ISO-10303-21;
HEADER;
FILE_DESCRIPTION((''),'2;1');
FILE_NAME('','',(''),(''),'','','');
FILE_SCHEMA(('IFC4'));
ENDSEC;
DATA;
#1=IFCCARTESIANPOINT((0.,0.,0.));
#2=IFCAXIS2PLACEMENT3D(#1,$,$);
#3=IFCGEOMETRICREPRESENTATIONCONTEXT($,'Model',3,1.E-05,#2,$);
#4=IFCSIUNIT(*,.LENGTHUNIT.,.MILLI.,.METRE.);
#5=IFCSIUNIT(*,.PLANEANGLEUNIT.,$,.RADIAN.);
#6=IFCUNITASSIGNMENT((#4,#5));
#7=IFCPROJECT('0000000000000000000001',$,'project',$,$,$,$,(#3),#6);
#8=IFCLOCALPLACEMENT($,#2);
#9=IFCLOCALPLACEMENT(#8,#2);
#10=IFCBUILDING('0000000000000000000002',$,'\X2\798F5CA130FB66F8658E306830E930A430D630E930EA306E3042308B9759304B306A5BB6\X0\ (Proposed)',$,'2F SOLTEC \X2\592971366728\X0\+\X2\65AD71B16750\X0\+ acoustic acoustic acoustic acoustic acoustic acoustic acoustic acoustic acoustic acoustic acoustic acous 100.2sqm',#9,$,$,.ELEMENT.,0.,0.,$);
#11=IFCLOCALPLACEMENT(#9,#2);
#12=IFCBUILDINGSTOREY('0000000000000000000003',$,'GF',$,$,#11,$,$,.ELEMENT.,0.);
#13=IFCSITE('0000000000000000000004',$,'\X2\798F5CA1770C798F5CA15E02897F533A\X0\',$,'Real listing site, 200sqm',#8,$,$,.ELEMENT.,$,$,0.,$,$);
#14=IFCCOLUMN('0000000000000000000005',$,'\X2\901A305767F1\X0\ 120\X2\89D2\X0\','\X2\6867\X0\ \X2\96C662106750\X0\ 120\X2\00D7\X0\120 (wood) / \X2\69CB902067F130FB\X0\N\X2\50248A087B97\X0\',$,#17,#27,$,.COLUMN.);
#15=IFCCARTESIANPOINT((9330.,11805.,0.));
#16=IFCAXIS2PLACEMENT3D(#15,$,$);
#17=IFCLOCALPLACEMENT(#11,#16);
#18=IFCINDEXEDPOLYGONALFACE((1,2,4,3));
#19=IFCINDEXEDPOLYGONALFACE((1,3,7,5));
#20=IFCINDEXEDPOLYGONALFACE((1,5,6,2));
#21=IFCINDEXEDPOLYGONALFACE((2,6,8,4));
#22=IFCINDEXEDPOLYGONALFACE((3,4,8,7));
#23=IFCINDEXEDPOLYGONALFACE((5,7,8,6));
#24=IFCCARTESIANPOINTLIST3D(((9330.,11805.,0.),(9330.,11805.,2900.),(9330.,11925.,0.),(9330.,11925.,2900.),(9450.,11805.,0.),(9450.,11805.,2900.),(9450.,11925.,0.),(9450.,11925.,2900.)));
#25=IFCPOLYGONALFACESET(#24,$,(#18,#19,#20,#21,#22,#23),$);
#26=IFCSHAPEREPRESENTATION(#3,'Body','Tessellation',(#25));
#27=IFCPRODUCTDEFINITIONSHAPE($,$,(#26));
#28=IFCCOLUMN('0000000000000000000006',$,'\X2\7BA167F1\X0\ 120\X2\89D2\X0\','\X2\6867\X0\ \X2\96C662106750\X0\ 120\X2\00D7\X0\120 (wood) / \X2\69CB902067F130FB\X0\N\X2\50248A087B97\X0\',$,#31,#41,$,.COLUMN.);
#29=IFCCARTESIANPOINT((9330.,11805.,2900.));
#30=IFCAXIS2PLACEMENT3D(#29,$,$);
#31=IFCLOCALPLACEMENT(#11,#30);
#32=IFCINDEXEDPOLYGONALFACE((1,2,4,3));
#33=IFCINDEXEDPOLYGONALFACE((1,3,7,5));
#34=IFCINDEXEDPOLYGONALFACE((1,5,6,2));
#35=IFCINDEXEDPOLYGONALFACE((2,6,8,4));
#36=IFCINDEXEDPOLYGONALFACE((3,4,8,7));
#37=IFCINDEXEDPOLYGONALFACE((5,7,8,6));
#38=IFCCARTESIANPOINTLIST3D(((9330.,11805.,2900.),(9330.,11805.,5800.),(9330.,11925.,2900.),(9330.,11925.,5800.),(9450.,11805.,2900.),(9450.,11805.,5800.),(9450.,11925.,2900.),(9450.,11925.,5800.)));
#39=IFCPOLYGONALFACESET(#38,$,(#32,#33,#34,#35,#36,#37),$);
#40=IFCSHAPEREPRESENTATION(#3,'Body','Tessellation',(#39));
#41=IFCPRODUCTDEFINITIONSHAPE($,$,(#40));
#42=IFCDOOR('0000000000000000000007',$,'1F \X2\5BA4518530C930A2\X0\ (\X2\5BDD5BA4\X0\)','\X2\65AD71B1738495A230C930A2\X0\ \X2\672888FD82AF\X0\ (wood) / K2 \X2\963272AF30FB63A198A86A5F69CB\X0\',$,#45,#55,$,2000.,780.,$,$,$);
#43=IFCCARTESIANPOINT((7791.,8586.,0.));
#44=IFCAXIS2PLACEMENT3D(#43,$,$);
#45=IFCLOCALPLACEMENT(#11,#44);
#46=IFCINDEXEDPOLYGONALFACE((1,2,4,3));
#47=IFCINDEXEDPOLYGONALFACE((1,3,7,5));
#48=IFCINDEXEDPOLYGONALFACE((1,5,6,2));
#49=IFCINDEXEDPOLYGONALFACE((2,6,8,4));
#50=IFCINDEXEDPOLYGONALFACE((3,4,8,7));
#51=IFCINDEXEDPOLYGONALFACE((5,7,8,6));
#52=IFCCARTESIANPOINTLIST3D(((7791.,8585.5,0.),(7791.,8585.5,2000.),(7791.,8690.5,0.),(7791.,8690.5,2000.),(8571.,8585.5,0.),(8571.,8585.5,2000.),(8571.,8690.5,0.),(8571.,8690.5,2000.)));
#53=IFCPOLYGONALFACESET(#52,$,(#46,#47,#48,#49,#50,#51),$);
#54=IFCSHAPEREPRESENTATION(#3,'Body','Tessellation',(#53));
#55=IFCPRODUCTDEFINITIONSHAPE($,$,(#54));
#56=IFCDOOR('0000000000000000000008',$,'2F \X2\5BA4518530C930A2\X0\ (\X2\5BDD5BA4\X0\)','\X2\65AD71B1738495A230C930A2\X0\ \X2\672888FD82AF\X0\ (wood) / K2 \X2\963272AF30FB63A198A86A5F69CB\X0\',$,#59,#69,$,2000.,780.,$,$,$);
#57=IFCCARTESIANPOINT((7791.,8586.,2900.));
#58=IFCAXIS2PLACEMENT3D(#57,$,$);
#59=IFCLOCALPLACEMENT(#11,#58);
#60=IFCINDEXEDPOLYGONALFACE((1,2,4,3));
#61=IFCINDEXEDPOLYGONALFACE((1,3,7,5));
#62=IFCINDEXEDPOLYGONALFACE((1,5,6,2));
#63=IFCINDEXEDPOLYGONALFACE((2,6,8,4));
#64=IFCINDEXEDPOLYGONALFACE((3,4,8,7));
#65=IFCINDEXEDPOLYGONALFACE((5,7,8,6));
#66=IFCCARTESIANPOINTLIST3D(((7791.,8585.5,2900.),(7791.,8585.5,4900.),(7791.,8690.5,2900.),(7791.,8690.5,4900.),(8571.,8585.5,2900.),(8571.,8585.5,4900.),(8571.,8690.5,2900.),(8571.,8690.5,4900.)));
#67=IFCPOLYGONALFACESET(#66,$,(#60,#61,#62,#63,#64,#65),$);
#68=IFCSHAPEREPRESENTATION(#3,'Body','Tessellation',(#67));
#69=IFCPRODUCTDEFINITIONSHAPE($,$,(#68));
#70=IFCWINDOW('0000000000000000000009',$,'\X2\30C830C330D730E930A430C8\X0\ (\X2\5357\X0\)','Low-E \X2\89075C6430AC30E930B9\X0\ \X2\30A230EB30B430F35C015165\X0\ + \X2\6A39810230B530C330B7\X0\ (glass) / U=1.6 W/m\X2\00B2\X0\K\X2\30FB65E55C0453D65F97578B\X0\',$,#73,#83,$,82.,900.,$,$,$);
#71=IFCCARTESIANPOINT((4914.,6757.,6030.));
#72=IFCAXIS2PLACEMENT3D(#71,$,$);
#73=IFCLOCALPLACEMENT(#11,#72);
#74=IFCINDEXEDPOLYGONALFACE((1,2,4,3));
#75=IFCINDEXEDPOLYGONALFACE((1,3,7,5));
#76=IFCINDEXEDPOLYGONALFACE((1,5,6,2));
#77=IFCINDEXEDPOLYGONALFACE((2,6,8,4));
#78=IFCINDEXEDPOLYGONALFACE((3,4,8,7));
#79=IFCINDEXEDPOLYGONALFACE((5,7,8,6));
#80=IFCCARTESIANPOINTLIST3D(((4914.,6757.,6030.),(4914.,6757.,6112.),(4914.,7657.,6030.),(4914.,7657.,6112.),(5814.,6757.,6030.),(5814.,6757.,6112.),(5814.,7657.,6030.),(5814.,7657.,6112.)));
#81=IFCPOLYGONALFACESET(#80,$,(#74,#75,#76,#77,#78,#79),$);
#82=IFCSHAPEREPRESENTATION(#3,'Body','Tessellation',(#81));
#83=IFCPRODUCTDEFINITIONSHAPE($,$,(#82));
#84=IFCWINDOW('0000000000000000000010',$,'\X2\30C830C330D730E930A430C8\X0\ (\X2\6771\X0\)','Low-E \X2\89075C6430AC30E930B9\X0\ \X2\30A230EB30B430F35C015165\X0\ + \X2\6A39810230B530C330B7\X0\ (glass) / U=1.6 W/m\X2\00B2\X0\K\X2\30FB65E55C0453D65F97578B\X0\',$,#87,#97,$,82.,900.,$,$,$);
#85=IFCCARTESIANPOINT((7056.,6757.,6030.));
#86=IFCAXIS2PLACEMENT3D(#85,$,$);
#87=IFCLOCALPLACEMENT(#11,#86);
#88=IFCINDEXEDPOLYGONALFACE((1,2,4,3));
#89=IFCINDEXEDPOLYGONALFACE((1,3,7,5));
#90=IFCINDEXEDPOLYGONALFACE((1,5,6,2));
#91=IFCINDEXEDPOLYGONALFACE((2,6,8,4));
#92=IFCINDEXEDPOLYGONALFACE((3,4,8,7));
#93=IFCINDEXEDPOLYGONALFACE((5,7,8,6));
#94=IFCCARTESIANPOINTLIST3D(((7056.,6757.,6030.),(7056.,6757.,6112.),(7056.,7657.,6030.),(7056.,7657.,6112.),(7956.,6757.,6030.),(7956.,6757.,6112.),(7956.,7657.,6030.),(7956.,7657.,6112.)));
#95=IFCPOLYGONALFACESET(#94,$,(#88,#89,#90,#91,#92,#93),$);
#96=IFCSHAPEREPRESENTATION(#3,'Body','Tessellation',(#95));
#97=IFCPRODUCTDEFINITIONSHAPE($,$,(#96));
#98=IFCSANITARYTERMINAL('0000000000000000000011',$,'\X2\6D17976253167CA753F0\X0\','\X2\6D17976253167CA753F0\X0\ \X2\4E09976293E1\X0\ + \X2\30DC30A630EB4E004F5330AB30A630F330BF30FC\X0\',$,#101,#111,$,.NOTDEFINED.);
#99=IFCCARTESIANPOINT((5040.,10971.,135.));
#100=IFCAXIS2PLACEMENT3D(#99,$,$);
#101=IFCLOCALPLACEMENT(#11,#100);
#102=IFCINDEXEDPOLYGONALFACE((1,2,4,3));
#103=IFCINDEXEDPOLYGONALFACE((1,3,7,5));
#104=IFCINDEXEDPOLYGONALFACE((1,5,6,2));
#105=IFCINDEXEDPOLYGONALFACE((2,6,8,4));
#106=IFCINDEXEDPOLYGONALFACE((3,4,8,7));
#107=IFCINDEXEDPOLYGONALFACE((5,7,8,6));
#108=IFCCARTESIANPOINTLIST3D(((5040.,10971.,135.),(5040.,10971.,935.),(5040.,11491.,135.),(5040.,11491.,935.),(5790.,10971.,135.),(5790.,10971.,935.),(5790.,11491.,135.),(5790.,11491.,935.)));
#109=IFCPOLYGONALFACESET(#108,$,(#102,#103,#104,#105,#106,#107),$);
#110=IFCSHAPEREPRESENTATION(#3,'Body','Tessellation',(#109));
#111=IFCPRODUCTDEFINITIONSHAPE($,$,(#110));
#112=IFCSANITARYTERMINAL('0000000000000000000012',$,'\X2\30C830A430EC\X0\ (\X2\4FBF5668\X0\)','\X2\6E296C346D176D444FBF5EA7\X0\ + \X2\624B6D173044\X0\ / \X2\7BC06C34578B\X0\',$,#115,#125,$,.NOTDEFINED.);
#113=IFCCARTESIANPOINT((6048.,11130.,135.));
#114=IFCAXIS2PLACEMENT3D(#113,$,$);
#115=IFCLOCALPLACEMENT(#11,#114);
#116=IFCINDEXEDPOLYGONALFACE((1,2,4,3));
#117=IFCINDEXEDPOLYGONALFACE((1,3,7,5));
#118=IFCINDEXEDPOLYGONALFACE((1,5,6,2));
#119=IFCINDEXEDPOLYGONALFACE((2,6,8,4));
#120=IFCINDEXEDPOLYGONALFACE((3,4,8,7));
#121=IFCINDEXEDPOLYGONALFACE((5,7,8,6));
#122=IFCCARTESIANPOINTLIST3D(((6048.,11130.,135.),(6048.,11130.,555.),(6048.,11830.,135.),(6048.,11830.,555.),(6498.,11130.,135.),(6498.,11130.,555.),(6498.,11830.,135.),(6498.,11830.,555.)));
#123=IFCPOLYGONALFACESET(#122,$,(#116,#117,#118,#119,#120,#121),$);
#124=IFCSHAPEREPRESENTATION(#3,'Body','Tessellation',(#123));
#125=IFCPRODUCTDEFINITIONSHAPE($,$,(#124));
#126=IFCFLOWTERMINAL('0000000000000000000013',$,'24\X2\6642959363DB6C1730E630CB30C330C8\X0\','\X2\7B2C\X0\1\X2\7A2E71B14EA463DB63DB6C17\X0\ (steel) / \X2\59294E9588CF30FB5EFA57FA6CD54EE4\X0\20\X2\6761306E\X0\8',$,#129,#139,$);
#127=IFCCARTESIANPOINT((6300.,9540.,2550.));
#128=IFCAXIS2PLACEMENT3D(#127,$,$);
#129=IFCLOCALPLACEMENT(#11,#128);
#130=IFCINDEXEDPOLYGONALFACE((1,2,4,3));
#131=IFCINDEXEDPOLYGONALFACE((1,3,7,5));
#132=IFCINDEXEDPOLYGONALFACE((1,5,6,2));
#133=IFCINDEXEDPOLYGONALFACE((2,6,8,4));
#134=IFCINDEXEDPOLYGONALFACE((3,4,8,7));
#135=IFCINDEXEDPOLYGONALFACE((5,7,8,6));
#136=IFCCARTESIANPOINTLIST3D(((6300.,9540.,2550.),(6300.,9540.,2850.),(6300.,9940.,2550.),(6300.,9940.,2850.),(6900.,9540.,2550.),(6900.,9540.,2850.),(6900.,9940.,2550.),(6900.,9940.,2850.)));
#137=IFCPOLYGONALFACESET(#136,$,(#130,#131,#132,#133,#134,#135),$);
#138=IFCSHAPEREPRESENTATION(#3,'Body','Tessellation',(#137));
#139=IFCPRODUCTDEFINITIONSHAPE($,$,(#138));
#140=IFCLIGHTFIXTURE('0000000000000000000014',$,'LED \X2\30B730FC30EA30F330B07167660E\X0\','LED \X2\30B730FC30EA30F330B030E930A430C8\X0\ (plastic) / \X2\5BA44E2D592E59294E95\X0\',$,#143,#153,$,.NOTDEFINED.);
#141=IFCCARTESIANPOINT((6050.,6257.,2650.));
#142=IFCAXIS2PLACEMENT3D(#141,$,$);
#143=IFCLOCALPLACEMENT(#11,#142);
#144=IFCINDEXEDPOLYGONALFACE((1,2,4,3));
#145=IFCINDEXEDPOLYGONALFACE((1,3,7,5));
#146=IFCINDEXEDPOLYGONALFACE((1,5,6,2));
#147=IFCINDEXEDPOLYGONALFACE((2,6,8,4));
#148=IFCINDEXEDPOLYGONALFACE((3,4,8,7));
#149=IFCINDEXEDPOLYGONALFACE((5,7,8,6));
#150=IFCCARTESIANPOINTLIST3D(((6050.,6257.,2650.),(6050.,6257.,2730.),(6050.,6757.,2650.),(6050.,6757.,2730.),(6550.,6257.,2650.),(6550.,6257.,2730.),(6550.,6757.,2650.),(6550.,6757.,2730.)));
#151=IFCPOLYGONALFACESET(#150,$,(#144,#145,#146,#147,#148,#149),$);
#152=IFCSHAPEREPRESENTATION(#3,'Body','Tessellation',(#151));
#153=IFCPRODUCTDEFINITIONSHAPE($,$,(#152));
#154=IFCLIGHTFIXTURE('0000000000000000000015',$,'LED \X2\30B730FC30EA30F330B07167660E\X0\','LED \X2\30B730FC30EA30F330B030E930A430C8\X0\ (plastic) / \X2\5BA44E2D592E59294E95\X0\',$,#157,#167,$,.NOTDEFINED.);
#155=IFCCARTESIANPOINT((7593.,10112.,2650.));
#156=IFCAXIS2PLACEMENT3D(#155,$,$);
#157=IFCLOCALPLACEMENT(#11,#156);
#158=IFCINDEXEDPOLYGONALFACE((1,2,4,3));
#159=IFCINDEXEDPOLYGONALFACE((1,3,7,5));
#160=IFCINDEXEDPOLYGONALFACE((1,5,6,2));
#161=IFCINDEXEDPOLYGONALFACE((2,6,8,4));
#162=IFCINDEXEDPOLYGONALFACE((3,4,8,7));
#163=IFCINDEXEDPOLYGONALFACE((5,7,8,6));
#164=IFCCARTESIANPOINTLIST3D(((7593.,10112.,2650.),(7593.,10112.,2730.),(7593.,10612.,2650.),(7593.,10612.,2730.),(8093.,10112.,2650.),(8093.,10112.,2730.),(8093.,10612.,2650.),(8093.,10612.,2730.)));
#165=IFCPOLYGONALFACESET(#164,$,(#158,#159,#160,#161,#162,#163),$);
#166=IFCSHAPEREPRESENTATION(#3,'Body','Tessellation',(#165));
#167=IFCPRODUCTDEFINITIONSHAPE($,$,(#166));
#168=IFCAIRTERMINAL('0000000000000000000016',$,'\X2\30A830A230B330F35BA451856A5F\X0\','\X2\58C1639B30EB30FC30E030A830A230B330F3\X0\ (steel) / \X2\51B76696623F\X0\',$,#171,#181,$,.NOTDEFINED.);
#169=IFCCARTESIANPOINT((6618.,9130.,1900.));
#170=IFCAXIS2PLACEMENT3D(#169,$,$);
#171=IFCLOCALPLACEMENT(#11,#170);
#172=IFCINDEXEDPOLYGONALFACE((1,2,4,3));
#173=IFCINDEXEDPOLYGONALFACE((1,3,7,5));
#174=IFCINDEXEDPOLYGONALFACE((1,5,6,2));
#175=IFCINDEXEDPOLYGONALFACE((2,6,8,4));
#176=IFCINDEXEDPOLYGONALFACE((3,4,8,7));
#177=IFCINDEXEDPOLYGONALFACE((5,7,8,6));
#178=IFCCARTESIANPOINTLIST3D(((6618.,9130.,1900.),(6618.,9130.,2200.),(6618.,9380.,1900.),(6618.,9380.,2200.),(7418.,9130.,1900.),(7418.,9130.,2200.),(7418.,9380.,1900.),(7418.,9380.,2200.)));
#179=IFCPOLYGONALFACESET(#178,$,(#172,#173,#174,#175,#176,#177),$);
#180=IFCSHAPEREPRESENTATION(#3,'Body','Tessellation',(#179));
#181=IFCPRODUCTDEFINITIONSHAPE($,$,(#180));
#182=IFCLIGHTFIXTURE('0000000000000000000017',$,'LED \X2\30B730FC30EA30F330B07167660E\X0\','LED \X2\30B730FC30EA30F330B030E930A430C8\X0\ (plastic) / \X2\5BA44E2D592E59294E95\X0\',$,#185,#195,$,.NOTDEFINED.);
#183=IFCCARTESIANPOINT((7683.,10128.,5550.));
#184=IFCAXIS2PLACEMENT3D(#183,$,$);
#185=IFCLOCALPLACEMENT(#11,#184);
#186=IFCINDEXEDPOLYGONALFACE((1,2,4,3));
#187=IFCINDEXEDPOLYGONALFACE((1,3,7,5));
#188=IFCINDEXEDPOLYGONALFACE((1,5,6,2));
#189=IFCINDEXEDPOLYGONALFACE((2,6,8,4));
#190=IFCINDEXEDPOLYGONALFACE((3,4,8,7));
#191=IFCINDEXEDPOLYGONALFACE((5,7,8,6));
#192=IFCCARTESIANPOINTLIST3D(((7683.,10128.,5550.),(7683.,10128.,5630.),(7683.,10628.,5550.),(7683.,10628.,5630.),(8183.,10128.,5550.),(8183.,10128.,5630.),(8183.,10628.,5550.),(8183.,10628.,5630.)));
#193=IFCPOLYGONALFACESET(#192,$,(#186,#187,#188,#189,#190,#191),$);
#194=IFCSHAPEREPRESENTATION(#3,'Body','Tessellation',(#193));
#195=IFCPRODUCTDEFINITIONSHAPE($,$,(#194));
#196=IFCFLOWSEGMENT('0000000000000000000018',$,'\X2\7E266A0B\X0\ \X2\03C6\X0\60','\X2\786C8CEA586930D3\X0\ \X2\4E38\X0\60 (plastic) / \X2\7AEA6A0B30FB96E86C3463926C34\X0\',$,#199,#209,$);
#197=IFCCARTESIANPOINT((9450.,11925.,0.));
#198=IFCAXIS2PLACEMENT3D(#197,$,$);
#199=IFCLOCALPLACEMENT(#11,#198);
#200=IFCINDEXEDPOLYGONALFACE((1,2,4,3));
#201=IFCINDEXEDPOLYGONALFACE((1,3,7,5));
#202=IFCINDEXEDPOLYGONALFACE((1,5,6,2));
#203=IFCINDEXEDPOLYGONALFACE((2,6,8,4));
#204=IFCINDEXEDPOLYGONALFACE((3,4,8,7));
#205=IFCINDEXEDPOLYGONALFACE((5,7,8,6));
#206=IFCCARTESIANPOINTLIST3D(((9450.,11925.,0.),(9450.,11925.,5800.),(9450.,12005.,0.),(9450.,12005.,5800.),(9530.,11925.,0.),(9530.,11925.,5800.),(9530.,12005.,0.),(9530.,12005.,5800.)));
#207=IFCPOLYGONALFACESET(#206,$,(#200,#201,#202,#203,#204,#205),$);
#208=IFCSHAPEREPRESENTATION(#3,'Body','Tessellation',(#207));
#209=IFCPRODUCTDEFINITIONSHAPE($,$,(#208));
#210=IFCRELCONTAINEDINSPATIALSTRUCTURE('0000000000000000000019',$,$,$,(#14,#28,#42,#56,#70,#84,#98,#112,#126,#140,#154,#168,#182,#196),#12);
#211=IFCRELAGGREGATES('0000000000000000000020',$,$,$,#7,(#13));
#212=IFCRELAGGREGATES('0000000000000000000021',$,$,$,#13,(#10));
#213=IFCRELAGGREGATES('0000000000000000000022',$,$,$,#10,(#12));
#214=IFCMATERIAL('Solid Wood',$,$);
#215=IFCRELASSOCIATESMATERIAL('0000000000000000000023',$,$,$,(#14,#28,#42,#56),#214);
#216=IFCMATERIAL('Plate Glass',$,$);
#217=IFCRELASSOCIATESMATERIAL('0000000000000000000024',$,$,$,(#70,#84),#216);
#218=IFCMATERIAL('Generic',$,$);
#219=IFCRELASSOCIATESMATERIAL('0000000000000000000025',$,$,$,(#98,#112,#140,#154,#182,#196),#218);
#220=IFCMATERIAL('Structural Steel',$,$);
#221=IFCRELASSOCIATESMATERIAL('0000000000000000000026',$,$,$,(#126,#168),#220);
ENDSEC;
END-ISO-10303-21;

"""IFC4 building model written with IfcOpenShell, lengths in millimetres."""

from ifc_helpers import new_model, si_unit, frame, frame_2d, origin, place, context, project, spatial, rectangle, extrude, material, element, save


model = new_model("IFC4")

# Units and contexts
model_context = context("Model", 3, precision=1e-05, world=origin())
ifc_project = project(units=[si_unit("LENGTHUNIT", "METRE", prefix="MILLI"), si_unit("PLANEANGLEUNIT", "RADIAN")], contexts=[model_context])

# Site, building, storey
site_placement = place(None, origin())
site = spatial("IfcSite", under=ifc_project, at=site_placement, Name="福岡県福岡市西区", ObjectType="Real listing site, 200sqm", CompositionType="ELEMENT", RefElevation=0.0)
building_placement = place(site_placement, origin())
building = spatial("IfcBuilding", under=site, at=building_placement, Name="福岡・書斎とライブラリのある静かな家 (Proposed)", ObjectType="2F SOLTEC 天然木+断熱材+ acoustic acoustic acoustic acoustic acoustic acoustic acoustic acoustic acoustic acoustic acoustic acous 100.2sqm", CompositionType="ELEMENT", ElevationOfRefHeight=0.0, ElevationOfTerrain=0.0)
storey_placement = place(building_placement, origin())
storey = spatial("IfcBuildingStorey", under=building, at=storey_placement, Name="GF", CompositionType="ELEMENT", Elevation=0.0)

# Columns
ifc_material_1 = material(Name="Solid Wood")
column_1_placement = place(storey_placement, frame((9330.0, 11805.0, 0.0)))
element("IfcColumn", 1, at=column_1_placement, inside=storey, material=ifc_material_1, Name="通し柱 120角", Description="桧 集成材 120×120 (wood) / 構造柱・N値計算", PredefinedType="COLUMN", context=model_context, shape_type="SweptSolid", body=[
    extrude(rectangle(XDim=120.0, YDim=120.0, at=frame_2d((60.0, 60.0))), frame((9330.0, 11805.0, 0.0)), (0.0, 0.0, 1.0), 2900.0),
])
column_2_placement = place(storey_placement, frame((9330.0, 11805.0, 2900.0)))
element("IfcColumn", 2, at=column_2_placement, inside=storey, material=ifc_material_1, Name="管柱 120角", Description="桧 集成材 120×120 (wood) / 構造柱・N値計算", PredefinedType="COLUMN", context=model_context, shape_type="SweptSolid", body=[
    extrude(rectangle(XDim=120.0, YDim=120.0, at=frame_2d((60.0, 60.0))), frame((9330.0, 11805.0, 2900.0)), (0.0, 0.0, 1.0), 2900.0),
])

# Door
door_1_placement = place(storey_placement, frame((7791.0, 8586.0, 0.0)))
element("IfcDoor", 3, at=door_1_placement, inside=storey, material=ifc_material_1, Name="1F 室内ドア (寝室)", Description="断熱玄関ドア 木製芯 (wood) / K2 防犯・採風機構", OverallHeight=2000.0, OverallWidth=780.0, context=model_context, shape_type="SweptSolid", body=[
    extrude(rectangle(XDim=780.0, YDim=105.0, at=frame_2d((390.0, 52.0))), frame((7791.0, 8586.0, 0.0)), (0.0, 0.0, 1.0), 2000.0),
])

# Door
door_2_placement = place(storey_placement, frame((7791.0, 8586.0, 2900.0)))
element("IfcDoor", 4, at=door_2_placement, inside=storey, material=ifc_material_1, Name="2F 室内ドア (寝室)", Description="断熱玄関ドア 木製芯 (wood) / K2 防犯・採風機構", OverallHeight=2000.0, OverallWidth=780.0, context=model_context, shape_type="SweptSolid", body=[
    extrude(rectangle(XDim=780.0, YDim=105.0, at=frame_2d((390.0, 52.0))), frame((7791.0, 8586.0, 2900.0)), (0.0, 0.0, 1.0), 2000.0),
])

# Windows
ifc_material_2 = material(Name="Plate Glass")
window_1_placement = place(storey_placement, frame((4914.0, 6757.0, 6030.0)))
element("IfcWindow", 5, at=window_1_placement, inside=storey, material=ifc_material_2, Name="トップライト (南)", Description="Low-E 複層ガラス アルゴン封入 + 樹脂サッシ (glass) / U=1.6 W/m²K・日射取得型", OverallHeight=82.0, OverallWidth=900.0, context=model_context, shape_type="SweptSolid", body=[
    extrude(rectangle(XDim=900.0, YDim=900.0, at=frame_2d((450.0, 450.0))), frame((4914.0, 6757.0, 6030.0)), (0.0, 0.0, 1.0), 82.0),
])
window_2_placement = place(storey_placement, frame((7056.0, 6757.0, 6030.0)))
element("IfcWindow", 6, at=window_2_placement, inside=storey, material=ifc_material_2, Name="トップライト (東)", Description="Low-E 複層ガラス アルゴン封入 + 樹脂サッシ (glass) / U=1.6 W/m²K・日射取得型", OverallHeight=82.0, OverallWidth=900.0, context=model_context, shape_type="SweptSolid", body=[
    extrude(rectangle(XDim=900.0, YDim=900.0, at=frame_2d((450.0, 450.0))), frame((7056.0, 6757.0, 6030.0)), (0.0, 0.0, 1.0), 82.0),
])

# Sanitary terminals
ifc_material_3 = material(Name="Generic")
sanitary_terminal_1_placement = place(storey_placement, frame((5040.0, 10971.0, 135.0)))
element("IfcSanitaryTerminal", 7, at=sanitary_terminal_1_placement, inside=storey, material=ifc_material_3, Name="洗面化粧台", Description="洗面化粧台 三面鏡 + ボウル一体カウンター", PredefinedType="NOTDEFINED", context=model_context, shape_type="SweptSolid", body=[
    extrude(rectangle(XDim=750.0, YDim=520.0, at=frame_2d((375.0, 260.0))), frame((5040.0, 10971.0, 135.0)), (0.0, 0.0, 1.0), 800.0),
])
sanitary_terminal_2_placement = place(storey_placement, frame((6048.0, 11130.0, 135.0)))
element("IfcSanitaryTerminal", 8, at=sanitary_terminal_2_placement, inside=storey, material=ifc_material_3, Name="トイレ (便器)", Description="温水洗浄便座 + 手洗い / 節水型", PredefinedType="NOTDEFINED", context=model_context, shape_type="SweptSolid", body=[
    extrude(rectangle(XDim=450.0, YDim=700.0, at=frame_2d((225.0, 350.0))), frame((6048.0, 11130.0, 135.0)), (0.0, 0.0, 1.0), 420.0),
])

# Flow terminal
ifc_material_4 = material(Name="Structural Steel")
flow_terminal_placement = place(storey_placement, frame((6300.0, 9540.0, 2550.0)))
element("IfcFlowTerminal", 9, at=flow_terminal_placement, inside=storey, material=ifc_material_4, Name="24時間換気ユニット", Description="第1種熱交換換気 (steel) / 天井裏・建基法令20条の8", context=model_context, shape_type="SweptSolid", body=[
    extrude(rectangle(XDim=600.0, YDim=400.0, at=frame_2d((300.0, 200.0))), frame((6300.0, 9540.0, 2550.0)), (0.0, 0.0, 1.0), 300.0),
])

# Light fixtures
light_fixture_1_placement = place(storey_placement, frame((6050.0, 6257.0, 2650.0)))
element("IfcLightFixture", 10, at=light_fixture_1_placement, inside=storey, material=ifc_material_3, Name="LED シーリング照明", Description="LED シーリングライト (plastic) / 室中央天井", PredefinedType="NOTDEFINED", context=model_context, shape_type="SweptSolid", body=[
    extrude(rectangle(XDim=500.0, YDim=500.0, at=frame_2d((250.0, 250.0))), frame((6050.0, 6257.0, 2650.0)), (0.0, 0.0, 1.0), 80.0),
])
light_fixture_2_placement = place(storey_placement, frame((7593.0, 10112.0, 2650.0)))
element("IfcLightFixture", 11, at=light_fixture_2_placement, inside=storey, material=ifc_material_3, Name="LED シーリング照明", Description="LED シーリングライト (plastic) / 室中央天井", PredefinedType="NOTDEFINED", context=model_context, shape_type="SweptSolid", body=[
    extrude(rectangle(XDim=500.0, YDim=500.0, at=frame_2d((250.0, 250.0))), frame((7593.0, 10112.0, 2650.0)), (0.0, 0.0, 1.0), 80.0),
])

# Air terminal
air_terminal_placement = place(storey_placement, frame((6618.0, 9130.0, 1900.0)))
element("IfcAirTerminal", 12, at=air_terminal_placement, inside=storey, material=ifc_material_4, Name="エアコン室内機", Description="壁掛ルームエアコン (steel) / 冷暖房", PredefinedType="NOTDEFINED", context=model_context, shape_type="SweptSolid", body=[
    extrude(rectangle(XDim=800.0, YDim=250.0, at=frame_2d((400.0, 125.0))), frame((6618.0, 9130.0, 1900.0)), (0.0, 0.0, 1.0), 300.0),
])

# Light fixture
light_fixture_3_placement = place(storey_placement, frame((7683.0, 10128.0, 5550.0)))
element("IfcLightFixture", 13, at=light_fixture_3_placement, inside=storey, material=ifc_material_3, Name="LED シーリング照明", Description="LED シーリングライト (plastic) / 室中央天井", PredefinedType="NOTDEFINED", context=model_context, shape_type="SweptSolid", body=[
    extrude(rectangle(XDim=500.0, YDim=500.0, at=frame_2d((250.0, 250.0))), frame((7683.0, 10128.0, 5550.0)), (0.0, 0.0, 1.0), 80.0),
])

# Flow segment
flow_segment_placement = place(storey_placement, frame((9450.0, 11925.0, 0.0)))
element("IfcFlowSegment", 14, at=flow_segment_placement, inside=storey, material=ifc_material_3, Name="縦樋 φ60", Description="硬質塩ビ 丸60 (plastic) / 竪樋・雨水排水", context=model_context, shape_type="SweptSolid", body=[
    extrude(rectangle(XDim=80.0, YDim=80.0, at=frame_2d((40.0, 40.0))), frame((9450.0, 11925.0, 0.0)), (0.0, 0.0, 1.0), 5800.0),
])

save(model, "model.ifc")
